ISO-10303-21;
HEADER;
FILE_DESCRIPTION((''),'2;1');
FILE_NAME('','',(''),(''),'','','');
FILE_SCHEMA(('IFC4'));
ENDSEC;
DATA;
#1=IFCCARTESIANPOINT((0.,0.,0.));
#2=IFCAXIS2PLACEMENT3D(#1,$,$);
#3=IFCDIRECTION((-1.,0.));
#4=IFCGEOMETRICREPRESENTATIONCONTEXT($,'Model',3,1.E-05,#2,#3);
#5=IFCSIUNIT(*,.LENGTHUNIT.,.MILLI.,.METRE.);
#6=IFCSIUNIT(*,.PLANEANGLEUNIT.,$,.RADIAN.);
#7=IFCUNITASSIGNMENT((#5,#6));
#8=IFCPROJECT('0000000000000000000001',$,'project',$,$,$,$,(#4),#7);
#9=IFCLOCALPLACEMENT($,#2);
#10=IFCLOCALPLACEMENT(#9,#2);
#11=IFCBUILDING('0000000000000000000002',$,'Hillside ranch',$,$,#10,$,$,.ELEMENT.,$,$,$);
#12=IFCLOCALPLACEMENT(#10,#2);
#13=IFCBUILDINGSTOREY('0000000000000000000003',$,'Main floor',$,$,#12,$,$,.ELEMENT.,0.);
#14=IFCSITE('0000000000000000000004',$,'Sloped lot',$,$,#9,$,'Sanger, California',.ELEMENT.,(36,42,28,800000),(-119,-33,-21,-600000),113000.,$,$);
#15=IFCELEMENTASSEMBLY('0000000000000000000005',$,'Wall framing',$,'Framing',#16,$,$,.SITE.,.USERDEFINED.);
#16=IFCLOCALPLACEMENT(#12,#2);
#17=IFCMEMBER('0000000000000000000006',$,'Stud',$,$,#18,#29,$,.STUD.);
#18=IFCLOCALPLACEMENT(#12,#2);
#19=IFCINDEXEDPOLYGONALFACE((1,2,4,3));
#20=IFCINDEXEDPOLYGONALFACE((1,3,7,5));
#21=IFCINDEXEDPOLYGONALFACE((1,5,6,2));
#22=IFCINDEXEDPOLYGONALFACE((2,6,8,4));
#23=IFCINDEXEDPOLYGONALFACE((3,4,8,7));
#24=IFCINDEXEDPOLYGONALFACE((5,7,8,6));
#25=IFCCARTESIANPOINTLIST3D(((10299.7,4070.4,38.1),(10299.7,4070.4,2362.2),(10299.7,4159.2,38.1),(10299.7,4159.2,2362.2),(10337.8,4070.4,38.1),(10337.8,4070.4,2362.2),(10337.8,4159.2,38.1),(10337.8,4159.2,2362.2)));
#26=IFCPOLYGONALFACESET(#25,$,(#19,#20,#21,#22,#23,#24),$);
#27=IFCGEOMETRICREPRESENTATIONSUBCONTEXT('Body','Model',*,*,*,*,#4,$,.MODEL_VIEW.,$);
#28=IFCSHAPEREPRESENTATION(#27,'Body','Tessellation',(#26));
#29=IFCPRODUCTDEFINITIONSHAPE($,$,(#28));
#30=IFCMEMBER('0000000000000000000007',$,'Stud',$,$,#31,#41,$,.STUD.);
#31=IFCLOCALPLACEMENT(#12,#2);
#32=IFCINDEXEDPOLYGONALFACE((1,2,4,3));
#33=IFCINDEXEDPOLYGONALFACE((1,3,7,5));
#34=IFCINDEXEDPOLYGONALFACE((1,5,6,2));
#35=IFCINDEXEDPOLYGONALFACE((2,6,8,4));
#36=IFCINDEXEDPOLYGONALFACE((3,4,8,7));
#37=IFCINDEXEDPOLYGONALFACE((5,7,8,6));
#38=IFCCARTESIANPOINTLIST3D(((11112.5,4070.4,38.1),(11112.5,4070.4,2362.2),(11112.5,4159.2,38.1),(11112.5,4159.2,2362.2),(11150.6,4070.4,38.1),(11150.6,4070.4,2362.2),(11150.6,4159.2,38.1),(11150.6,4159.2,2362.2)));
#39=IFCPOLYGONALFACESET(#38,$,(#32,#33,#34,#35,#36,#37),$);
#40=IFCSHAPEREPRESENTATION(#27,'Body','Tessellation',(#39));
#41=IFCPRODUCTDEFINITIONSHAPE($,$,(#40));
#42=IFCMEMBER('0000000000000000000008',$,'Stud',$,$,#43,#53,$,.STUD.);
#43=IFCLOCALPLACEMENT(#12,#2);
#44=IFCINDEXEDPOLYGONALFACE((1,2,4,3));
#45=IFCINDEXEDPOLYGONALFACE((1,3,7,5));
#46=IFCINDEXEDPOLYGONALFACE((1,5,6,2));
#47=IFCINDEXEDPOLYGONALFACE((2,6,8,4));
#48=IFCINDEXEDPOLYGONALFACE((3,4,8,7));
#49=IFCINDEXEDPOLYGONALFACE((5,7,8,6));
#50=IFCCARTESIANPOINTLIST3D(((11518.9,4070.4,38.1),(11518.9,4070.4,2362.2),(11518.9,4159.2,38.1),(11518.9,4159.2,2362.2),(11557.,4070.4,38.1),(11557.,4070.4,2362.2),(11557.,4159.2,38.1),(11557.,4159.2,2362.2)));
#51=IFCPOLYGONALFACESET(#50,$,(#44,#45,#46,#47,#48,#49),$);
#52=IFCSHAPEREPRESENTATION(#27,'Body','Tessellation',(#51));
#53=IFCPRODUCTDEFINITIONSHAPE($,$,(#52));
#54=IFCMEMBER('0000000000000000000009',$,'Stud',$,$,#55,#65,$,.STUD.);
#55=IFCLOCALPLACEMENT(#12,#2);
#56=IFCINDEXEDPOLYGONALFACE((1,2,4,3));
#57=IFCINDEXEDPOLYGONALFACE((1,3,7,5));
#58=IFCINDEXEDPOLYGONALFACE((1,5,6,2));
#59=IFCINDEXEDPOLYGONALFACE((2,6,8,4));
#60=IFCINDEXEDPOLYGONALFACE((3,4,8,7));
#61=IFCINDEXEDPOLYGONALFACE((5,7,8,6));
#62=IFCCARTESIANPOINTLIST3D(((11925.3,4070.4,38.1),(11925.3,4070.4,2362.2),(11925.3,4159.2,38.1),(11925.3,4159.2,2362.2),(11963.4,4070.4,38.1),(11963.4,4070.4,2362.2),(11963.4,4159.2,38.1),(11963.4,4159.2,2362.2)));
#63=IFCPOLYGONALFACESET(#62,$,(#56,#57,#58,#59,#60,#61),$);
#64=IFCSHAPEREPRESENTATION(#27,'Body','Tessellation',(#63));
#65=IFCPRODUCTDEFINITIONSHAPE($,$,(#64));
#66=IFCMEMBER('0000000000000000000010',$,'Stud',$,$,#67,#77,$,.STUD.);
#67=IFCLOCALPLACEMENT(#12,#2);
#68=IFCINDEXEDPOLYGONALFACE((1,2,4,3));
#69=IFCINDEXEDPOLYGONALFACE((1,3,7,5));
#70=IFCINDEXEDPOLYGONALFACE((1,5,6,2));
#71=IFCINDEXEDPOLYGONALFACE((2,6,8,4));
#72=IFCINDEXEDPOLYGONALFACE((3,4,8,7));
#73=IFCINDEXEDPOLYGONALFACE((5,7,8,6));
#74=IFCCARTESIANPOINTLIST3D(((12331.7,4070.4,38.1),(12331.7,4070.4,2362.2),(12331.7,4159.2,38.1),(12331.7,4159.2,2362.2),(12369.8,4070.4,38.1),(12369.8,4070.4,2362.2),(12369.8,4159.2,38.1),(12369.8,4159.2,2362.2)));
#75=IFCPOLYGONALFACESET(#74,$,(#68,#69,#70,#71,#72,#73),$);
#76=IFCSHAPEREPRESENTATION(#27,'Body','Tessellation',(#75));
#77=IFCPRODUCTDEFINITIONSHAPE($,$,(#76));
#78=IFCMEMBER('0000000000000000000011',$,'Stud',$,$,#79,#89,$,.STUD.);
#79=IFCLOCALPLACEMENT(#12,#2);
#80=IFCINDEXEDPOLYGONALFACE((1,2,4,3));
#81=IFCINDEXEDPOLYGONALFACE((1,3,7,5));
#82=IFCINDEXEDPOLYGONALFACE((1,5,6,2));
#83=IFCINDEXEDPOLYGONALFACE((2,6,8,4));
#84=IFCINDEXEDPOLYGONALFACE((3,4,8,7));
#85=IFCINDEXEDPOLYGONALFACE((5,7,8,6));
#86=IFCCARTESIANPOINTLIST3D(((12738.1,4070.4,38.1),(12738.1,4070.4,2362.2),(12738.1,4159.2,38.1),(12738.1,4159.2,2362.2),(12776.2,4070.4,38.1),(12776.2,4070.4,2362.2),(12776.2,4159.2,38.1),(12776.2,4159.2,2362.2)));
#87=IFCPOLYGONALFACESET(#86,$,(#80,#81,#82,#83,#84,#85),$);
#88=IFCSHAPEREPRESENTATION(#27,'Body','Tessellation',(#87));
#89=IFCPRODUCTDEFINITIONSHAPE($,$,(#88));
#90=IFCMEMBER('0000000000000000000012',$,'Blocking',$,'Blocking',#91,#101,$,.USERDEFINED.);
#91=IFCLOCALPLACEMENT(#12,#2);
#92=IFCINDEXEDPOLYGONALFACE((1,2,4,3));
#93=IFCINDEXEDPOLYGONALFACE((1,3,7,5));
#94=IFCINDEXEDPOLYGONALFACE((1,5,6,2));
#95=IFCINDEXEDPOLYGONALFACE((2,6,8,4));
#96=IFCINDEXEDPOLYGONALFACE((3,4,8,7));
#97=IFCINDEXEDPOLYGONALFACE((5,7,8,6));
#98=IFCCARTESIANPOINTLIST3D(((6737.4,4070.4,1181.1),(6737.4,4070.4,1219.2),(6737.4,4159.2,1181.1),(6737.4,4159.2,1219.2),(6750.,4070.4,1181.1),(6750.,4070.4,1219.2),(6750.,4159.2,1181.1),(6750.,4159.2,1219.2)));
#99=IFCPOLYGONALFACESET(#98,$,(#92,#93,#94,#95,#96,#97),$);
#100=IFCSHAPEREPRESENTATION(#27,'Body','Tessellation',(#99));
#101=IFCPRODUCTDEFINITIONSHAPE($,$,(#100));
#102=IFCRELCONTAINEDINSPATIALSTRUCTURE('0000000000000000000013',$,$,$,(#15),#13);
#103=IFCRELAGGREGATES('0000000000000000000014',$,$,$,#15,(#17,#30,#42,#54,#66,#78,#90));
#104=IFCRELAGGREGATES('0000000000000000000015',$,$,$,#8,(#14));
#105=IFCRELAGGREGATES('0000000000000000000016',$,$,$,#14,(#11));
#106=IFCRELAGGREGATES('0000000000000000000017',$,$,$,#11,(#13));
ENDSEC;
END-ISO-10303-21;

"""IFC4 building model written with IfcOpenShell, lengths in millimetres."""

from ifc_helpers import new_model, si_unit, direction, frame, origin, origin_with_axes, place, context, subcontext, project, spatial, polyline, outline, extrude, element, aggregate, save


model = new_model("IFC4")

# Units and contexts
model_context = context("Model", 3, precision=1e-05, world=origin(), true_north=direction((-1.0, 0.0)))
body_context = subcontext(model_context, "Body", "Model", "MODEL_VIEW")
ifc_project = project(units=[si_unit("LENGTHUNIT", "METRE", prefix="MILLI"), si_unit("PLANEANGLEUNIT", "RADIAN")], contexts=[model_context])

# Site, building, storey
site_placement = place(None, origin())
site = spatial("IfcSite", under=ifc_project, at=site_placement, Name="Sloped lot", LongName="Sanger, California", CompositionType="ELEMENT", RefLatitude=(36, 42, 28, 800000), RefLongitude=(-119, -33, -21, -600000), RefElevation=113000.0)
building_placement = place(site_placement, origin())
building = spatial("IfcBuilding", under=site, at=building_placement, Name="Hillside ranch", CompositionType="ELEMENT")
storey_placement = place(building_placement, origin())
storey = spatial("IfcBuildingStorey", under=building, at=storey_placement, Name="Main floor", CompositionType="ELEMENT", Elevation=0.0)

# Element assembly, members
assembly_placement = place(storey_placement, origin_with_axes())
assembly = element("IfcElementAssembly", 1, at=assembly_placement, inside=storey, Name="Wall framing", ObjectType="Framing", AssemblyPlace="SITE", PredefinedType="USERDEFINED")
member_1_placement = place(storey_placement, origin_with_axes())
member_1 = element("IfcMember", 2, at=member_1_placement, Name="Stud", PredefinedType="STUD", context=body_context, shape_type="SweptSolid", body=[
    extrude(outline(polyline([(0.0, 0.0), (38.1, 0.0), (38.1, 88.9), (0.0, 88.9), (0.0, 0.0)])), frame((10299.7, 4070.3, 38.1), z_axis=(0.0, 0.0, 1.0), x_axis=(1.0, 0.0, 0.0)), (0.0, 0.0, 1.0), 2324.1),
])
member_2_placement = place(storey_placement, origin_with_axes())
member_2 = element("IfcMember", 3, at=member_2_placement, Name="Stud", PredefinedType="STUD", context=body_context, shape_type="SweptSolid", body=[
    extrude(outline(polyline([(0.0, 0.0), (38.1, 0.0), (38.1, 88.9), (0.0, 88.9), (0.0, 0.0)])), frame((11112.5, 4070.3, 38.1), z_axis=(0.0, 0.0, 1.0), x_axis=(1.0, 0.0, 0.0)), (0.0, 0.0, 1.0), 2324.1),
])
member_3_placement = place(storey_placement, origin_with_axes())
member_3 = element("IfcMember", 4, at=member_3_placement, Name="Stud", PredefinedType="STUD", context=body_context, shape_type="SweptSolid", body=[
    extrude(outline(polyline([(0.0, 0.0), (38.1, 0.0), (38.1, 88.9), (0.0, 88.9), (0.0, 0.0)])), frame((11518.9, 4070.3, 38.1), z_axis=(0.0, 0.0, 1.0), x_axis=(1.0, 0.0, 0.0)), (0.0, 0.0, 1.0), 2324.1),
])
member_4_placement = place(storey_placement, origin_with_axes())
member_4 = element("IfcMember", 5, at=member_4_placement, Name="Stud", PredefinedType="STUD", context=body_context, shape_type="SweptSolid", body=[
    extrude(outline(polyline([(0.0, 0.0), (38.1, 0.0), (38.1, 88.9), (0.0, 88.9), (0.0, 0.0)])), frame((11925.3, 4070.3, 38.1), z_axis=(0.0, 0.0, 1.0), x_axis=(1.0, 0.0, 0.0)), (0.0, 0.0, 1.0), 2324.1),
])
member_5_placement = place(storey_placement, origin_with_axes())
member_5 = element("IfcMember", 6, at=member_5_placement, Name="Stud", PredefinedType="STUD", context=body_context, shape_type="SweptSolid", body=[
    extrude(outline(polyline([(0.0, 0.0), (38.1, 0.0), (38.1, 88.9), (0.0, 88.9), (0.0, 0.0)])), frame((12331.7, 4070.3, 38.1), z_axis=(0.0, 0.0, 1.0), x_axis=(1.0, 0.0, 0.0)), (0.0, 0.0, 1.0), 2324.1),
])
member_6_placement = place(storey_placement, origin_with_axes())
member_6 = element("IfcMember", 7, at=member_6_placement, Name="Stud", PredefinedType="STUD", context=body_context, shape_type="SweptSolid", body=[
    extrude(outline(polyline([(0.0, 0.0), (38.1, 0.0), (38.1, 88.9), (0.0, 88.9), (0.0, 0.0)])), frame((12738.1, 4070.3, 38.1), z_axis=(0.0, 0.0, 1.0), x_axis=(1.0, 0.0, 0.0)), (0.0, 0.0, 1.0), 2324.1),
])
member_7_placement = place(storey_placement, origin_with_axes())
member_7 = element("IfcMember", 8, at=member_7_placement, Name="Blocking", ObjectType="Blocking", PredefinedType="USERDEFINED", context=body_context, shape_type="SweptSolid", body=[
    extrude(outline(polyline([(0.0, 0.0), (12.7, 0.0), (12.7, 88.9), (0.0, 88.9), (0.0, 0.0)])), frame((6737.4, 4070.3, 1181.1), z_axis=(0.0, 0.0, 1.0), x_axis=(1.0, 0.0, 0.0)), (0.0, 0.0, 1.0), 38.1),
])
aggregate(assembly, [member_1, member_2, member_3, member_4, member_5, member_6, member_7])

save(model, "model.ifc")
